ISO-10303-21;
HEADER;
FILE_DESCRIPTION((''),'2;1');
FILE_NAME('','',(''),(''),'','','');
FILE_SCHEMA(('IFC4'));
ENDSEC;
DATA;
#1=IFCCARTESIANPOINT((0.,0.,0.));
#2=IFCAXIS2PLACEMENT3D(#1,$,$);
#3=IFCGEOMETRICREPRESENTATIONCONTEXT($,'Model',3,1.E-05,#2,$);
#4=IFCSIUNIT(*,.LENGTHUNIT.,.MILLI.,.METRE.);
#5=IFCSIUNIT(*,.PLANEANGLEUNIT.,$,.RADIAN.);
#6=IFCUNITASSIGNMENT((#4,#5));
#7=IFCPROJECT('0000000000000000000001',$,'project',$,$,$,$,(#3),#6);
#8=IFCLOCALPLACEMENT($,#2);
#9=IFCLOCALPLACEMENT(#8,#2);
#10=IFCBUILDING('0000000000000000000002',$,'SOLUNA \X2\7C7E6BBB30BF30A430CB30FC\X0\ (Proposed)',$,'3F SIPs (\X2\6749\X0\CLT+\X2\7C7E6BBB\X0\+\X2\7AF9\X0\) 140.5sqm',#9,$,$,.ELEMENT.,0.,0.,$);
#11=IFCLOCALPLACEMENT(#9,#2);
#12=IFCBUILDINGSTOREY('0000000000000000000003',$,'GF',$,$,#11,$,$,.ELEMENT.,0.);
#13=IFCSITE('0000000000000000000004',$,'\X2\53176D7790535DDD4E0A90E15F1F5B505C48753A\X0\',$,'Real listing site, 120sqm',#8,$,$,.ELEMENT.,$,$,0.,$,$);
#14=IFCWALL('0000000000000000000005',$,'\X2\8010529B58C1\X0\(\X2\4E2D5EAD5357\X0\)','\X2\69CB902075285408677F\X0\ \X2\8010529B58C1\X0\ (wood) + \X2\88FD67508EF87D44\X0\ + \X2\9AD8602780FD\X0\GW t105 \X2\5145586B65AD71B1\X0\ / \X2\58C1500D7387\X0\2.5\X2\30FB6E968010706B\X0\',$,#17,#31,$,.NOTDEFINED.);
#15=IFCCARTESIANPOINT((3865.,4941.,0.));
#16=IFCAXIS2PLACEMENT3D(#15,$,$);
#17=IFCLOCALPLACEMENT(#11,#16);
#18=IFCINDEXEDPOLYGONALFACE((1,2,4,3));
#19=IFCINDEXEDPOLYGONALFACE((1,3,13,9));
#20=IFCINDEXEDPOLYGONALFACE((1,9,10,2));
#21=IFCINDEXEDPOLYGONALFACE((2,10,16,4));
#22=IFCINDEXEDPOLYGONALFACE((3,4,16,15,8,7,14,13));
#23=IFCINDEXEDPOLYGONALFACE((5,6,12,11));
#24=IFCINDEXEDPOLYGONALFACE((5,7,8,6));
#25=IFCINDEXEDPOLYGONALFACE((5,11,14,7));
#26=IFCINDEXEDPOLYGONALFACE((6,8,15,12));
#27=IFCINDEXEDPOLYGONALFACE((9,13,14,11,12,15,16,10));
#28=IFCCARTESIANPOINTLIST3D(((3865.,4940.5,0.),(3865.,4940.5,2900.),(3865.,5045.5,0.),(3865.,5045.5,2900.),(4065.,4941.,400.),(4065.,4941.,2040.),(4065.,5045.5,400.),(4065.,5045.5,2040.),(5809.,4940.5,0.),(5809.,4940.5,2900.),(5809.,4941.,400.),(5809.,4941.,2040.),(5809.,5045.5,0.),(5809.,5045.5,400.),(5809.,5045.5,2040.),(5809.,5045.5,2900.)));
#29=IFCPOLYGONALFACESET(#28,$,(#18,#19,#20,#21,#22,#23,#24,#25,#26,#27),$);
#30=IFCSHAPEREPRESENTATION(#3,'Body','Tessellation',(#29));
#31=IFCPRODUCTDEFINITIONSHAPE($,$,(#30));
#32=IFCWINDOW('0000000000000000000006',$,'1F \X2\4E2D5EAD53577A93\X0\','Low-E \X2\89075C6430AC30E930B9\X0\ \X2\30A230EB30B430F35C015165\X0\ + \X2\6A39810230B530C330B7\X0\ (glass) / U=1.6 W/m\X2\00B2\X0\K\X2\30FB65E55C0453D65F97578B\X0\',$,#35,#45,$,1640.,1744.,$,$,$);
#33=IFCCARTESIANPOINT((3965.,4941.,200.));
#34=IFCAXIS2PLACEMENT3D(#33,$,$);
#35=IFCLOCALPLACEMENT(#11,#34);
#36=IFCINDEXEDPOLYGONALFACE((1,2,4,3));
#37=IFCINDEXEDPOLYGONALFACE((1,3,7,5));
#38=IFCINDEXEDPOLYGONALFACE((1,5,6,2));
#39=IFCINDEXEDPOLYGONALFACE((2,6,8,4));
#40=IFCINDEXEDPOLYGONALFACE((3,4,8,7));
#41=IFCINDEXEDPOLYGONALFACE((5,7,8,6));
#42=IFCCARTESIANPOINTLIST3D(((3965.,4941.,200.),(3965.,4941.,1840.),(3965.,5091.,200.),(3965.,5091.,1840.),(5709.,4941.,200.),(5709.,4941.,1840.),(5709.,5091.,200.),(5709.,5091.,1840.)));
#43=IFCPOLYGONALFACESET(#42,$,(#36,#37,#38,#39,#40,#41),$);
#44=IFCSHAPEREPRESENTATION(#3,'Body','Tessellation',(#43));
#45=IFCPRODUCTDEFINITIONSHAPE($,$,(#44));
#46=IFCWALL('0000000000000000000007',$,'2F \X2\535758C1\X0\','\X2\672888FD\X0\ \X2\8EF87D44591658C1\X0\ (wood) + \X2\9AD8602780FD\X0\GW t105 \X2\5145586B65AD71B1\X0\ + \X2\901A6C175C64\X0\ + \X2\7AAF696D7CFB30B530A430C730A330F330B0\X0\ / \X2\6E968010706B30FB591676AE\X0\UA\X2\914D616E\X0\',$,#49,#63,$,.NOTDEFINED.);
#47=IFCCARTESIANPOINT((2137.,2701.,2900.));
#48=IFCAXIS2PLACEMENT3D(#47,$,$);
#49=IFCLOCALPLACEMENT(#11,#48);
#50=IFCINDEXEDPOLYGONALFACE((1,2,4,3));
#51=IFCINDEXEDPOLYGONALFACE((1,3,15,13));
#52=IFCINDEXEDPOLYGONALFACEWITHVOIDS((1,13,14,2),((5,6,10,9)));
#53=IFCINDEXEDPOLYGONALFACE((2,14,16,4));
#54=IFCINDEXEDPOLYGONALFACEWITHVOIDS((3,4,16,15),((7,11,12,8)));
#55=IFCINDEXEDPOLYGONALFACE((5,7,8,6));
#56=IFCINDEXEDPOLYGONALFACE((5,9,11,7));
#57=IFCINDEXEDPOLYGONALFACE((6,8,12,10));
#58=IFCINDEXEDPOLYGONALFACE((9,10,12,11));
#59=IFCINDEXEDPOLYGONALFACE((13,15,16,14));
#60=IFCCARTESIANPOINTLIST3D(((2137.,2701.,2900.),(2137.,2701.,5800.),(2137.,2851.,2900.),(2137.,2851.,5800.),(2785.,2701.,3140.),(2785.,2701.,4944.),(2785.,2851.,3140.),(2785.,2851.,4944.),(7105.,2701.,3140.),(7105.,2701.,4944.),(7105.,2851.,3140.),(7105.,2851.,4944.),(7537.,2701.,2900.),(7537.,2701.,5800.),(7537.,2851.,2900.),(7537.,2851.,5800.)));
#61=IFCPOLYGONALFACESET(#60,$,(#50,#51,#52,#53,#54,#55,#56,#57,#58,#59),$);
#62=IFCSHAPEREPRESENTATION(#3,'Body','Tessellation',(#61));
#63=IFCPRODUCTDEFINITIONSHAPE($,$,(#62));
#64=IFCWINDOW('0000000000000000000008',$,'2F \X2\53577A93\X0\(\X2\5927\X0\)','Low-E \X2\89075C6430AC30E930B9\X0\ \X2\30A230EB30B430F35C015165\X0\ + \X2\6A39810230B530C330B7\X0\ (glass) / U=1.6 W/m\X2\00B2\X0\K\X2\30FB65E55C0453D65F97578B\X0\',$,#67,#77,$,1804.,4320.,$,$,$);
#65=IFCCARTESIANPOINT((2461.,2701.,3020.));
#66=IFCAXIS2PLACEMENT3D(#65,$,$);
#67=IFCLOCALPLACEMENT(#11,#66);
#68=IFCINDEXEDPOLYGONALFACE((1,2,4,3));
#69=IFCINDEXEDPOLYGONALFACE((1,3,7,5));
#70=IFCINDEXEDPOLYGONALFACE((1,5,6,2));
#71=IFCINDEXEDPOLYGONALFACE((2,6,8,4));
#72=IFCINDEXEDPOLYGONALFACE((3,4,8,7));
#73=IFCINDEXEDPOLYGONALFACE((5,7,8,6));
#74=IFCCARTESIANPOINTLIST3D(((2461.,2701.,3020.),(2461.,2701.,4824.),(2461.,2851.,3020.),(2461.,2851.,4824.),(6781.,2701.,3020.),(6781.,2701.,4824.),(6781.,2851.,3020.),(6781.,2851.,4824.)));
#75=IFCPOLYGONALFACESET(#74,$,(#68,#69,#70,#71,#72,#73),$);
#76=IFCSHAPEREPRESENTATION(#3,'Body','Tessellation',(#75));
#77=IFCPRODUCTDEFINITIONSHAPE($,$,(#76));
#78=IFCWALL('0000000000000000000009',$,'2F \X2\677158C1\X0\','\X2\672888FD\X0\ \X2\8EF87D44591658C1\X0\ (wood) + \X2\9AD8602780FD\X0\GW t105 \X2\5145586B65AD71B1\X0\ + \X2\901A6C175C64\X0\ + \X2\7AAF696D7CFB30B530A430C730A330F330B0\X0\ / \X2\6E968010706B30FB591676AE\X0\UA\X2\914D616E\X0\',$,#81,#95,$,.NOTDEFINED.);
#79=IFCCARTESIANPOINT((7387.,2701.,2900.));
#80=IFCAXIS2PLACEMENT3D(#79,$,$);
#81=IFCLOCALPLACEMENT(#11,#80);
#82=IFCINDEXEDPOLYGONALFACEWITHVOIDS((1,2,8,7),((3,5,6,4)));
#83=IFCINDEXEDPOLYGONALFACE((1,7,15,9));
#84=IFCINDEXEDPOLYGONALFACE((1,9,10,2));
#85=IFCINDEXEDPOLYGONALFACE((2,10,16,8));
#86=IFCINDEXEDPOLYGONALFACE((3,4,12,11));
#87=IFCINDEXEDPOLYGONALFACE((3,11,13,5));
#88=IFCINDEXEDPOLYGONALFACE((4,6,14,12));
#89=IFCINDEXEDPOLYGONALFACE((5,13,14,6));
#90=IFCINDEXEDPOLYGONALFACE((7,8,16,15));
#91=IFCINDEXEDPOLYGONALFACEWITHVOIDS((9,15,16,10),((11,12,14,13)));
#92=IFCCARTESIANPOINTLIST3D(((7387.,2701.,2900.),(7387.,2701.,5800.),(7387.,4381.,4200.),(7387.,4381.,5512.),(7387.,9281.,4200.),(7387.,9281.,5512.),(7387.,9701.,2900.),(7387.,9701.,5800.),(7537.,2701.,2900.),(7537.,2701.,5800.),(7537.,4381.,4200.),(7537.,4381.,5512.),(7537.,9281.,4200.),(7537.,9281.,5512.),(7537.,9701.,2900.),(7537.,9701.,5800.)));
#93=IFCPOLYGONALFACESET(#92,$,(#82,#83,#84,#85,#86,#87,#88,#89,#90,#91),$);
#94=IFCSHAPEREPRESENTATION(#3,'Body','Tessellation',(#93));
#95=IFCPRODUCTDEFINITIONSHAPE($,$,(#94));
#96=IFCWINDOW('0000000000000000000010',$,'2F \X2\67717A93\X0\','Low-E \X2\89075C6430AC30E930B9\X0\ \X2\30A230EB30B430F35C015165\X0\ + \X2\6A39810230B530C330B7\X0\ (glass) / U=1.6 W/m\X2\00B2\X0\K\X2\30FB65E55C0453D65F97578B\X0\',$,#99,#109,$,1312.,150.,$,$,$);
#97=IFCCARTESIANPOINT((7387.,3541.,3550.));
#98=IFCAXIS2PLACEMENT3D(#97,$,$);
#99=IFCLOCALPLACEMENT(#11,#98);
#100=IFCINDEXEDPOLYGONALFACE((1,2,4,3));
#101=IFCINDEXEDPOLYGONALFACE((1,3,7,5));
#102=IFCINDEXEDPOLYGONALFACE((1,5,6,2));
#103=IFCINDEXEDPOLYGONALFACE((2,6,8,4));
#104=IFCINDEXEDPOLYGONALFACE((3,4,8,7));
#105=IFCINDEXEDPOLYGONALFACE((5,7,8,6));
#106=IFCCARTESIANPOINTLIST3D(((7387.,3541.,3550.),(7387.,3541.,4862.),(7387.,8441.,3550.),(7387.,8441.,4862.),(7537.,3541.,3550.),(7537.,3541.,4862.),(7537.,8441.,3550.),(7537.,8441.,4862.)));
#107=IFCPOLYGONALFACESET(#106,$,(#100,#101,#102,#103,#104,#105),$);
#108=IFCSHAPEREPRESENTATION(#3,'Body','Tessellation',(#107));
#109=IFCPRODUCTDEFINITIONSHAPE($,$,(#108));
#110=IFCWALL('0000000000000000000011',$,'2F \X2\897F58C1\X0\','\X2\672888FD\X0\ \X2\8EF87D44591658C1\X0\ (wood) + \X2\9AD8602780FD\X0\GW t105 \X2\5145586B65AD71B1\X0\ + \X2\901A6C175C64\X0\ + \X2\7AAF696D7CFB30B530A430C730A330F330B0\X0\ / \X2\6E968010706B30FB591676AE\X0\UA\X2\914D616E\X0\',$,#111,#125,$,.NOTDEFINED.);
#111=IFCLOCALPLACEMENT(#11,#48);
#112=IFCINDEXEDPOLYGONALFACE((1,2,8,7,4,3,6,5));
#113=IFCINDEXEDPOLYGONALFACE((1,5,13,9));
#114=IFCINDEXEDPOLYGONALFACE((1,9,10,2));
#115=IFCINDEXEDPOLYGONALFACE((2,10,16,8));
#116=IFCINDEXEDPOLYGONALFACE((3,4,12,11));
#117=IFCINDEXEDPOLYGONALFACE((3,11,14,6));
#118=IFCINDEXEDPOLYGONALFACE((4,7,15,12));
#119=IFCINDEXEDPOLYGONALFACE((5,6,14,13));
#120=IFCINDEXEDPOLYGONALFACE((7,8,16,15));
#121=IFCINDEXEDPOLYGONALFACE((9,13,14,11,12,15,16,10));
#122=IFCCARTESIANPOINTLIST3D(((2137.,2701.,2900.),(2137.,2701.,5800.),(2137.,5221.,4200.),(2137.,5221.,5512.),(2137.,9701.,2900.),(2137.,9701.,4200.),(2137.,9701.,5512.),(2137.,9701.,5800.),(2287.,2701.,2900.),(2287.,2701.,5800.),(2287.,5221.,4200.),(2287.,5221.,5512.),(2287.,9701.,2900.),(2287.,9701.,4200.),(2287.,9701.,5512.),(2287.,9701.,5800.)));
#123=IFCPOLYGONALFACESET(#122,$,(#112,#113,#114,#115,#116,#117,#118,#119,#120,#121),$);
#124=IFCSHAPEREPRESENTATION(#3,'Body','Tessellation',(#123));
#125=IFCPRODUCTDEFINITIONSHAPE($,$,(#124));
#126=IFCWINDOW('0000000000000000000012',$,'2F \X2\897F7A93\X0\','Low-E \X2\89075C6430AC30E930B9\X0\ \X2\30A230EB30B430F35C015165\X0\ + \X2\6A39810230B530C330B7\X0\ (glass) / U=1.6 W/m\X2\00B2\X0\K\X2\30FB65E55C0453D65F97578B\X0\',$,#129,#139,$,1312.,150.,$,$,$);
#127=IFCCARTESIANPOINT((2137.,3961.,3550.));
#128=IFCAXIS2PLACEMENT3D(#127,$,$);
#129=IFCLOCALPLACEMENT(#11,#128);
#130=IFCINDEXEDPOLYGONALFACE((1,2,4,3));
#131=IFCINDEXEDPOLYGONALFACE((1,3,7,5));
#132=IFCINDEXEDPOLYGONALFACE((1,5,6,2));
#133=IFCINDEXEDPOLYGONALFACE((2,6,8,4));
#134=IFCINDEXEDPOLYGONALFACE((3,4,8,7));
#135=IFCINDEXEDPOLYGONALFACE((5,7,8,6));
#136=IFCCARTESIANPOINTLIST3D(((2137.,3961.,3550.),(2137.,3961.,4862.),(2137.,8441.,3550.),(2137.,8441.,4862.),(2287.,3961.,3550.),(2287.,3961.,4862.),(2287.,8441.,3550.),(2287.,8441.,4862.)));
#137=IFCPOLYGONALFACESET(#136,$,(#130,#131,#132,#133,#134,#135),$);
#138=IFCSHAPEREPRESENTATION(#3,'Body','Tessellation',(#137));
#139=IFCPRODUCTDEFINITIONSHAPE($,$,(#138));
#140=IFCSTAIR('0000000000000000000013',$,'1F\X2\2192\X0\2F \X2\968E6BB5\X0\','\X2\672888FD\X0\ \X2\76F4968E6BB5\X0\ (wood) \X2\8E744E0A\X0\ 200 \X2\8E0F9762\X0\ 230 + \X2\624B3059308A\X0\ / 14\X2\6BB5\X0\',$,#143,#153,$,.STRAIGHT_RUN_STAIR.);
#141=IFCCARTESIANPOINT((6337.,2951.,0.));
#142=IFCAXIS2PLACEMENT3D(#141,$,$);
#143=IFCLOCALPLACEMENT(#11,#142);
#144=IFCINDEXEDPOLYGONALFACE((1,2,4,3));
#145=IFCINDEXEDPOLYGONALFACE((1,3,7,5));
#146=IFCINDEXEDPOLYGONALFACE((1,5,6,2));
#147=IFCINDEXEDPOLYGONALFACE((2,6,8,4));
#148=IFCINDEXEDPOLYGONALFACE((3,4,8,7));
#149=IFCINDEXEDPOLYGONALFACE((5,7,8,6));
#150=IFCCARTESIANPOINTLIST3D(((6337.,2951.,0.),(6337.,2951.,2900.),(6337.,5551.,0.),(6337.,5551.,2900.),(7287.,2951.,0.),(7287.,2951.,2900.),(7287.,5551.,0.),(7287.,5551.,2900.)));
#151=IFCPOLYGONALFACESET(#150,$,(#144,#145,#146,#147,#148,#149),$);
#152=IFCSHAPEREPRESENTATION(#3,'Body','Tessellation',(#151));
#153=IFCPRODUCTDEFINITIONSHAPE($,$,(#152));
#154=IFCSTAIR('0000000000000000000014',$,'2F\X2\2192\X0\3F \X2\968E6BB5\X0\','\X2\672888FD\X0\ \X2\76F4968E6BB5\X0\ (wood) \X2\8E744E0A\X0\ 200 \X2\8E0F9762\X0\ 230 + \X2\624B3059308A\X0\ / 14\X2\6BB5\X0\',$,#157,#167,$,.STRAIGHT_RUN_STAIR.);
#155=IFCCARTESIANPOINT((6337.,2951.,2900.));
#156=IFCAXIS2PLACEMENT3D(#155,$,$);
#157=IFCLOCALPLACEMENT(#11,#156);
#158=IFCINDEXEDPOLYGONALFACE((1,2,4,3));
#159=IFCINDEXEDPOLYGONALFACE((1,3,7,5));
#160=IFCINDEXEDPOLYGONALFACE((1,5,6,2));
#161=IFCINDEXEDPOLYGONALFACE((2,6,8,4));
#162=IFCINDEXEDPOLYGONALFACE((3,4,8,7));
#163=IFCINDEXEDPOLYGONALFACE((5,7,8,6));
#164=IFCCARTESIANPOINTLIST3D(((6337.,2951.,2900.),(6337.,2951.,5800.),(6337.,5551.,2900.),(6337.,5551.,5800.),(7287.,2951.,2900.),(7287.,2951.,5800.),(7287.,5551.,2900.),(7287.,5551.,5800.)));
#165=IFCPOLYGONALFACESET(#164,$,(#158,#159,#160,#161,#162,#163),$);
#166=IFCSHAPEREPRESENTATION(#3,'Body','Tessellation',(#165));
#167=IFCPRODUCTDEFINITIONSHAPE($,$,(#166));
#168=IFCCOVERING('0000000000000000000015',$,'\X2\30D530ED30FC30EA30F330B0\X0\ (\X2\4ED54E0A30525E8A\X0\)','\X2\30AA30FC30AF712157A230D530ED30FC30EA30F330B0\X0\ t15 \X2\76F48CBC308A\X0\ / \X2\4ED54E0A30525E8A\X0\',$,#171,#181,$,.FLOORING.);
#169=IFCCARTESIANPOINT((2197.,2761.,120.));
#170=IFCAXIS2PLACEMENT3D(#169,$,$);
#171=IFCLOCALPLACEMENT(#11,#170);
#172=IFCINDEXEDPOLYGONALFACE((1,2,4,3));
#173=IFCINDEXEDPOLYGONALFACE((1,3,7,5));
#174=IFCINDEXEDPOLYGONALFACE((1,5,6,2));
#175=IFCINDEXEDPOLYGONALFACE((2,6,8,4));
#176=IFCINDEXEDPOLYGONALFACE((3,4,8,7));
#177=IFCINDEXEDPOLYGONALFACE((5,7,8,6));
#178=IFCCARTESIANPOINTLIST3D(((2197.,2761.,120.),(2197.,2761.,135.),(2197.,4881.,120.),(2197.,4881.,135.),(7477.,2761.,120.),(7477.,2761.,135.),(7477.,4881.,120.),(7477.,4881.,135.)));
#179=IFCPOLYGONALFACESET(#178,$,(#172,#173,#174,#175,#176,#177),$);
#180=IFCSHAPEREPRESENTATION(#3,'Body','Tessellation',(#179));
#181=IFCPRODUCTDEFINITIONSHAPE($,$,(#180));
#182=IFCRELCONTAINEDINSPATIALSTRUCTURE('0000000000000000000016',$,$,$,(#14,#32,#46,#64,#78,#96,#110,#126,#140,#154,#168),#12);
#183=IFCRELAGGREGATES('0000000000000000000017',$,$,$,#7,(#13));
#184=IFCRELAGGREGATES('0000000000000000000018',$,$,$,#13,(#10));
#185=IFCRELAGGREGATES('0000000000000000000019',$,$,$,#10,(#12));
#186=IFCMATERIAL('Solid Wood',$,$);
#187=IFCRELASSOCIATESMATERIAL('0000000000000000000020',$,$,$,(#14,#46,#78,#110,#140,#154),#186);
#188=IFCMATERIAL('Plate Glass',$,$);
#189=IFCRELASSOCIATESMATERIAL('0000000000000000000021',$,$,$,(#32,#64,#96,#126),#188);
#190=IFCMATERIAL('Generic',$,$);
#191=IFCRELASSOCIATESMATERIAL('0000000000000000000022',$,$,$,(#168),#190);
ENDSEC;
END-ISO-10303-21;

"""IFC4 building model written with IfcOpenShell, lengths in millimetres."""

from ifc_helpers import new_model, si_unit, frame, frame_2d, origin, place, context, project, spatial, rectangle, extrude, material, element, fill, save


model = new_model("IFC4")

# Units and contexts
model_context = context("Model", 3, precision=1e-05, world=origin())
ifc_project = project(units=[si_unit("LENGTHUNIT", "METRE", prefix="MILLI"), si_unit("PLANEANGLEUNIT", "RADIAN")], contexts=[model_context])

# Site, building, storey
site_placement = place(None, origin())
site = spatial("IfcSite", under=ifc_project, at=site_placement, Name="北海道川上郡弟子屈町", ObjectType="Real listing site, 120sqm", CompositionType="ELEMENT", RefElevation=0.0)
building_placement = place(site_placement, origin())
building = spatial("IfcBuilding", under=site, at=building_placement, Name="SOLUNA 籾殻タイニー (Proposed)", ObjectType="3F SIPs (杉CLT+籾殻+竹) 140.5sqm", CompositionType="ELEMENT", ElevationOfRefHeight=0.0, ElevationOfTerrain=0.0)
storey_placement = place(building_placement, origin())
storey = spatial("IfcBuildingStorey", under=building, at=storey_placement, Name="GF", CompositionType="ELEMENT", Elevation=0.0)

# Shared definitions
ifc_material_1 = material(Name="Solid Wood")

# Shared definitions
ifc_material_2 = material(Name="Plate Glass")

# Walls, openings, windows
wall_1_placement = place(storey_placement, frame((3865.0, 4941.0, 0.0)))
wall_1 = element("IfcWall", 1, at=wall_1_placement, inside=storey, material=ifc_material_1, Name="耐力壁(中庭南)", Description="構造用合板 耐力壁 (wood) + 製材軸組 + 高性能GW t105 充填断熱 / 壁倍率2.5・準耐火", PredefinedType="NOTDEFINED", context=model_context, shape_type="SweptSolid", body=[
    extrude(rectangle(XDim=1944.0, YDim=105.0, at=frame_2d((972.0, 52.0))), frame((3865.0, 4941.0, 0.0)), (0.0, 0.0, 1.0), 2900.0),
])
opening_1_placement = place(storey_placement, frame((3965.0, 4941.0, 200.0)))
opening_1 = element("IfcOpeningElement", 2, at=opening_1_placement, cuts=wall_1, PredefinedType="NOTDEFINED", context=model_context, shape_type="SweptSolid", body=[
    extrude(rectangle(XDim=1744.0, YDim=150.0, at=frame_2d((872.0, 75.0))), frame((3965.0, 4941.0, 200.0)), (0.0, 0.0, 1.0), 1640.0),
])
window_1_placement = place(storey_placement, frame((3965.0, 4941.0, 200.0)))
window_1 = element("IfcWindow", 3, at=window_1_placement, inside=storey, material=ifc_material_2, Name="1F 中庭南窓", Description="Low-E 複層ガラス アルゴン封入 + 樹脂サッシ (glass) / U=1.6 W/m²K・日射取得型", OverallHeight=1640.0, OverallWidth=1744.0, context=model_context, shape_type="SweptSolid", body=[
    extrude(rectangle(XDim=1744.0, YDim=150.0, at=frame_2d((872.0, 75.0))), frame((3965.0, 4941.0, 200.0)), (0.0, 0.0, 1.0), 1640.0),
])
fill(opening_1, window_1)
wall_2_placement = place(storey_placement, frame((2137.0, 2701.0, 2900.0)))
wall_2 = element("IfcWall", 4, at=wall_2_placement, inside=storey, material=ifc_material_1, Name="2F 南壁", Description="木製 軸組外壁 (wood) + 高性能GW t105 充填断熱 + 通気層 + 窯業系サイディング / 準耐火・外皮UA配慮", PredefinedType="NOTDEFINED", context=model_context, shape_type="SweptSolid", body=[
    extrude(rectangle(XDim=5400.0, YDim=150.0, at=frame_2d((2700.0, 75.0))), frame((2137.0, 2701.0, 2900.0)), (0.0, 0.0, 1.0), 2900.0),
])
opening_2_placement = place(storey_placement, frame((2461.0, 2701.0, 3020.0)))
opening_2 = element("IfcOpeningElement", 5, at=opening_2_placement, cuts=wall_2, PredefinedType="NOTDEFINED", context=model_context, shape_type="SweptSolid", body=[
    extrude(rectangle(XDim=4320.0, YDim=150.0, at=frame_2d((2160.0, 75.0))), frame((2461.0, 2701.0, 3020.0)), (0.0, 0.0, 1.0), 1804.0),
])
window_2_placement = place(storey_placement, frame((2461.0, 2701.0, 3020.0)))
window_2 = element("IfcWindow", 6, at=window_2_placement, inside=storey, material=ifc_material_2, Name="2F 南窓(大)", Description="Low-E 複層ガラス アルゴン封入 + 樹脂サッシ (glass) / U=1.6 W/m²K・日射取得型", OverallHeight=1804.0, OverallWidth=4320.0, context=model_context, shape_type="SweptSolid", body=[
    extrude(rectangle(XDim=4320.0, YDim=150.0, at=frame_2d((2160.0, 75.0))), frame((2461.0, 2701.0, 3020.0)), (0.0, 0.0, 1.0), 1804.0),
])
fill(opening_2, window_2)
wall_3_placement = place(storey_placement, frame((7387.0, 2701.0, 2900.0)))
wall_3 = element("IfcWall", 7, at=wall_3_placement, inside=storey, material=ifc_material_1, Name="2F 東壁", Description="木製 軸組外壁 (wood) + 高性能GW t105 充填断熱 + 通気層 + 窯業系サイディング / 準耐火・外皮UA配慮", PredefinedType="NOTDEFINED", context=model_context, shape_type="SweptSolid", body=[
    extrude(rectangle(XDim=150.0, YDim=7000.0, at=frame_2d((75.0, 3500.0))), frame((7387.0, 2701.0, 2900.0)), (0.0, 0.0, 1.0), 2900.0),
])
opening_3_placement = place(storey_placement, frame((7387.0, 3541.0, 3550.0)))
opening_3 = element("IfcOpeningElement", 8, at=opening_3_placement, cuts=wall_3, PredefinedType="NOTDEFINED", context=model_context, shape_type="SweptSolid", body=[
    extrude(rectangle(XDim=150.0, YDim=4900.0, at=frame_2d((75.0, 2450.0))), frame((7387.0, 3541.0, 3550.0)), (0.0, 0.0, 1.0), 1312.0),
])
window_3_placement = place(storey_placement, frame((7387.0, 3541.0, 3550.0)))
window_3 = element("IfcWindow", 9, at=window_3_placement, inside=storey, material=ifc_material_2, Name="2F 東窓", Description="Low-E 複層ガラス アルゴン封入 + 樹脂サッシ (glass) / U=1.6 W/m²K・日射取得型", OverallHeight=1312.0, OverallWidth=150.0, context=model_context, shape_type="SweptSolid", body=[
    extrude(rectangle(XDim=150.0, YDim=4900.0, at=frame_2d((75.0, 2450.0))), frame((7387.0, 3541.0, 3550.0)), (0.0, 0.0, 1.0), 1312.0),
])
fill(opening_3, window_3)
wall_4_placement = place(storey_placement, frame((2137.0, 2701.0, 2900.0)))
wall_4 = element("IfcWall", 10, at=wall_4_placement, inside=storey, material=ifc_material_1, Name="2F 西壁", Description="木製 軸組外壁 (wood) + 高性能GW t105 充填断熱 + 通気層 + 窯業系サイディング / 準耐火・外皮UA配慮", PredefinedType="NOTDEFINED", context=model_context, shape_type="SweptSolid", body=[
    extrude(rectangle(XDim=150.0, YDim=7000.0, at=frame_2d((75.0, 3500.0))), frame((2137.0, 2701.0, 2900.0)), (0.0, 0.0, 1.0), 2900.0),
])
opening_4_placement = place(storey_placement, frame((2137.0, 3961.0, 3550.0)))
opening_4 = element("IfcOpeningElement", 11, at=opening_4_placement, cuts=wall_4, PredefinedType="NOTDEFINED", context=model_context, shape_type="SweptSolid", body=[
    extrude(rectangle(XDim=150.0, YDim=4480.0, at=frame_2d((75.0, 2240.0))), frame((2137.0, 3961.0, 3550.0)), (0.0, 0.0, 1.0), 1312.0),
])
window_4_placement = place(storey_placement, frame((2137.0, 3961.0, 3550.0)))
window_4 = element("IfcWindow", 12, at=window_4_placement, inside=storey, material=ifc_material_2, Name="2F 西窓", Description="Low-E 複層ガラス アルゴン封入 + 樹脂サッシ (glass) / U=1.6 W/m²K・日射取得型", OverallHeight=1312.0, OverallWidth=150.0, context=model_context, shape_type="SweptSolid", body=[
    extrude(rectangle(XDim=150.0, YDim=4480.0, at=frame_2d((75.0, 2240.0))), frame((2137.0, 3961.0, 3550.0)), (0.0, 0.0, 1.0), 1312.0),
])
fill(opening_4, window_4)

# Stairs
stair_1_placement = place(storey_placement, frame((6337.0, 2951.0, 0.0)))
element("IfcStair", 13, at=stair_1_placement, inside=storey, material=ifc_material_1, Name="1F→2F 階段", Description="木製 直階段 (wood) 蹴上 200 踏面 230 + 手すり / 14段", PredefinedType="STRAIGHT_RUN_STAIR", context=model_context, shape_type="SweptSolid", body=[
    extrude(rectangle(XDim=950.0, YDim=2600.0, at=frame_2d((475.0, 1300.0))), frame((6337.0, 2951.0, 0.0)), (0.0, 0.0, 1.0), 2900.0),
])
stair_2_placement = place(storey_placement, frame((6337.0, 2951.0, 2900.0)))
element("IfcStair", 14, at=stair_2_placement, inside=storey, material=ifc_material_1, Name="2F→3F 階段", Description="木製 直階段 (wood) 蹴上 200 踏面 230 + 手すり / 14段", PredefinedType="STRAIGHT_RUN_STAIR", context=model_context, shape_type="SweptSolid", body=[
    extrude(rectangle(XDim=950.0, YDim=2600.0, at=frame_2d((475.0, 1300.0))), frame((6337.0, 2951.0, 2900.0)), (0.0, 0.0, 1.0), 2900.0),
])

# Covering
ifc_material_3 = material(Name="Generic")
covering_placement = place(storey_placement, frame((2197.0, 2761.0, 120.0)))
element("IfcCovering", 15, at=covering_placement, inside=storey, material=ifc_material_3, Name="フローリング (仕上げ床)", Description="オーク無垢フローリング t15 直貼り / 仕上げ床", PredefinedType="FLOORING", context=model_context, shape_type="SweptSolid", body=[
    extrude(rectangle(XDim=5280.0, YDim=2120.0, at=frame_2d((2640.0, 1060.0))), frame((2197.0, 2761.0, 120.0)), (0.0, 0.0, 1.0), 15.0),
])

save(model, "model.ifc")
